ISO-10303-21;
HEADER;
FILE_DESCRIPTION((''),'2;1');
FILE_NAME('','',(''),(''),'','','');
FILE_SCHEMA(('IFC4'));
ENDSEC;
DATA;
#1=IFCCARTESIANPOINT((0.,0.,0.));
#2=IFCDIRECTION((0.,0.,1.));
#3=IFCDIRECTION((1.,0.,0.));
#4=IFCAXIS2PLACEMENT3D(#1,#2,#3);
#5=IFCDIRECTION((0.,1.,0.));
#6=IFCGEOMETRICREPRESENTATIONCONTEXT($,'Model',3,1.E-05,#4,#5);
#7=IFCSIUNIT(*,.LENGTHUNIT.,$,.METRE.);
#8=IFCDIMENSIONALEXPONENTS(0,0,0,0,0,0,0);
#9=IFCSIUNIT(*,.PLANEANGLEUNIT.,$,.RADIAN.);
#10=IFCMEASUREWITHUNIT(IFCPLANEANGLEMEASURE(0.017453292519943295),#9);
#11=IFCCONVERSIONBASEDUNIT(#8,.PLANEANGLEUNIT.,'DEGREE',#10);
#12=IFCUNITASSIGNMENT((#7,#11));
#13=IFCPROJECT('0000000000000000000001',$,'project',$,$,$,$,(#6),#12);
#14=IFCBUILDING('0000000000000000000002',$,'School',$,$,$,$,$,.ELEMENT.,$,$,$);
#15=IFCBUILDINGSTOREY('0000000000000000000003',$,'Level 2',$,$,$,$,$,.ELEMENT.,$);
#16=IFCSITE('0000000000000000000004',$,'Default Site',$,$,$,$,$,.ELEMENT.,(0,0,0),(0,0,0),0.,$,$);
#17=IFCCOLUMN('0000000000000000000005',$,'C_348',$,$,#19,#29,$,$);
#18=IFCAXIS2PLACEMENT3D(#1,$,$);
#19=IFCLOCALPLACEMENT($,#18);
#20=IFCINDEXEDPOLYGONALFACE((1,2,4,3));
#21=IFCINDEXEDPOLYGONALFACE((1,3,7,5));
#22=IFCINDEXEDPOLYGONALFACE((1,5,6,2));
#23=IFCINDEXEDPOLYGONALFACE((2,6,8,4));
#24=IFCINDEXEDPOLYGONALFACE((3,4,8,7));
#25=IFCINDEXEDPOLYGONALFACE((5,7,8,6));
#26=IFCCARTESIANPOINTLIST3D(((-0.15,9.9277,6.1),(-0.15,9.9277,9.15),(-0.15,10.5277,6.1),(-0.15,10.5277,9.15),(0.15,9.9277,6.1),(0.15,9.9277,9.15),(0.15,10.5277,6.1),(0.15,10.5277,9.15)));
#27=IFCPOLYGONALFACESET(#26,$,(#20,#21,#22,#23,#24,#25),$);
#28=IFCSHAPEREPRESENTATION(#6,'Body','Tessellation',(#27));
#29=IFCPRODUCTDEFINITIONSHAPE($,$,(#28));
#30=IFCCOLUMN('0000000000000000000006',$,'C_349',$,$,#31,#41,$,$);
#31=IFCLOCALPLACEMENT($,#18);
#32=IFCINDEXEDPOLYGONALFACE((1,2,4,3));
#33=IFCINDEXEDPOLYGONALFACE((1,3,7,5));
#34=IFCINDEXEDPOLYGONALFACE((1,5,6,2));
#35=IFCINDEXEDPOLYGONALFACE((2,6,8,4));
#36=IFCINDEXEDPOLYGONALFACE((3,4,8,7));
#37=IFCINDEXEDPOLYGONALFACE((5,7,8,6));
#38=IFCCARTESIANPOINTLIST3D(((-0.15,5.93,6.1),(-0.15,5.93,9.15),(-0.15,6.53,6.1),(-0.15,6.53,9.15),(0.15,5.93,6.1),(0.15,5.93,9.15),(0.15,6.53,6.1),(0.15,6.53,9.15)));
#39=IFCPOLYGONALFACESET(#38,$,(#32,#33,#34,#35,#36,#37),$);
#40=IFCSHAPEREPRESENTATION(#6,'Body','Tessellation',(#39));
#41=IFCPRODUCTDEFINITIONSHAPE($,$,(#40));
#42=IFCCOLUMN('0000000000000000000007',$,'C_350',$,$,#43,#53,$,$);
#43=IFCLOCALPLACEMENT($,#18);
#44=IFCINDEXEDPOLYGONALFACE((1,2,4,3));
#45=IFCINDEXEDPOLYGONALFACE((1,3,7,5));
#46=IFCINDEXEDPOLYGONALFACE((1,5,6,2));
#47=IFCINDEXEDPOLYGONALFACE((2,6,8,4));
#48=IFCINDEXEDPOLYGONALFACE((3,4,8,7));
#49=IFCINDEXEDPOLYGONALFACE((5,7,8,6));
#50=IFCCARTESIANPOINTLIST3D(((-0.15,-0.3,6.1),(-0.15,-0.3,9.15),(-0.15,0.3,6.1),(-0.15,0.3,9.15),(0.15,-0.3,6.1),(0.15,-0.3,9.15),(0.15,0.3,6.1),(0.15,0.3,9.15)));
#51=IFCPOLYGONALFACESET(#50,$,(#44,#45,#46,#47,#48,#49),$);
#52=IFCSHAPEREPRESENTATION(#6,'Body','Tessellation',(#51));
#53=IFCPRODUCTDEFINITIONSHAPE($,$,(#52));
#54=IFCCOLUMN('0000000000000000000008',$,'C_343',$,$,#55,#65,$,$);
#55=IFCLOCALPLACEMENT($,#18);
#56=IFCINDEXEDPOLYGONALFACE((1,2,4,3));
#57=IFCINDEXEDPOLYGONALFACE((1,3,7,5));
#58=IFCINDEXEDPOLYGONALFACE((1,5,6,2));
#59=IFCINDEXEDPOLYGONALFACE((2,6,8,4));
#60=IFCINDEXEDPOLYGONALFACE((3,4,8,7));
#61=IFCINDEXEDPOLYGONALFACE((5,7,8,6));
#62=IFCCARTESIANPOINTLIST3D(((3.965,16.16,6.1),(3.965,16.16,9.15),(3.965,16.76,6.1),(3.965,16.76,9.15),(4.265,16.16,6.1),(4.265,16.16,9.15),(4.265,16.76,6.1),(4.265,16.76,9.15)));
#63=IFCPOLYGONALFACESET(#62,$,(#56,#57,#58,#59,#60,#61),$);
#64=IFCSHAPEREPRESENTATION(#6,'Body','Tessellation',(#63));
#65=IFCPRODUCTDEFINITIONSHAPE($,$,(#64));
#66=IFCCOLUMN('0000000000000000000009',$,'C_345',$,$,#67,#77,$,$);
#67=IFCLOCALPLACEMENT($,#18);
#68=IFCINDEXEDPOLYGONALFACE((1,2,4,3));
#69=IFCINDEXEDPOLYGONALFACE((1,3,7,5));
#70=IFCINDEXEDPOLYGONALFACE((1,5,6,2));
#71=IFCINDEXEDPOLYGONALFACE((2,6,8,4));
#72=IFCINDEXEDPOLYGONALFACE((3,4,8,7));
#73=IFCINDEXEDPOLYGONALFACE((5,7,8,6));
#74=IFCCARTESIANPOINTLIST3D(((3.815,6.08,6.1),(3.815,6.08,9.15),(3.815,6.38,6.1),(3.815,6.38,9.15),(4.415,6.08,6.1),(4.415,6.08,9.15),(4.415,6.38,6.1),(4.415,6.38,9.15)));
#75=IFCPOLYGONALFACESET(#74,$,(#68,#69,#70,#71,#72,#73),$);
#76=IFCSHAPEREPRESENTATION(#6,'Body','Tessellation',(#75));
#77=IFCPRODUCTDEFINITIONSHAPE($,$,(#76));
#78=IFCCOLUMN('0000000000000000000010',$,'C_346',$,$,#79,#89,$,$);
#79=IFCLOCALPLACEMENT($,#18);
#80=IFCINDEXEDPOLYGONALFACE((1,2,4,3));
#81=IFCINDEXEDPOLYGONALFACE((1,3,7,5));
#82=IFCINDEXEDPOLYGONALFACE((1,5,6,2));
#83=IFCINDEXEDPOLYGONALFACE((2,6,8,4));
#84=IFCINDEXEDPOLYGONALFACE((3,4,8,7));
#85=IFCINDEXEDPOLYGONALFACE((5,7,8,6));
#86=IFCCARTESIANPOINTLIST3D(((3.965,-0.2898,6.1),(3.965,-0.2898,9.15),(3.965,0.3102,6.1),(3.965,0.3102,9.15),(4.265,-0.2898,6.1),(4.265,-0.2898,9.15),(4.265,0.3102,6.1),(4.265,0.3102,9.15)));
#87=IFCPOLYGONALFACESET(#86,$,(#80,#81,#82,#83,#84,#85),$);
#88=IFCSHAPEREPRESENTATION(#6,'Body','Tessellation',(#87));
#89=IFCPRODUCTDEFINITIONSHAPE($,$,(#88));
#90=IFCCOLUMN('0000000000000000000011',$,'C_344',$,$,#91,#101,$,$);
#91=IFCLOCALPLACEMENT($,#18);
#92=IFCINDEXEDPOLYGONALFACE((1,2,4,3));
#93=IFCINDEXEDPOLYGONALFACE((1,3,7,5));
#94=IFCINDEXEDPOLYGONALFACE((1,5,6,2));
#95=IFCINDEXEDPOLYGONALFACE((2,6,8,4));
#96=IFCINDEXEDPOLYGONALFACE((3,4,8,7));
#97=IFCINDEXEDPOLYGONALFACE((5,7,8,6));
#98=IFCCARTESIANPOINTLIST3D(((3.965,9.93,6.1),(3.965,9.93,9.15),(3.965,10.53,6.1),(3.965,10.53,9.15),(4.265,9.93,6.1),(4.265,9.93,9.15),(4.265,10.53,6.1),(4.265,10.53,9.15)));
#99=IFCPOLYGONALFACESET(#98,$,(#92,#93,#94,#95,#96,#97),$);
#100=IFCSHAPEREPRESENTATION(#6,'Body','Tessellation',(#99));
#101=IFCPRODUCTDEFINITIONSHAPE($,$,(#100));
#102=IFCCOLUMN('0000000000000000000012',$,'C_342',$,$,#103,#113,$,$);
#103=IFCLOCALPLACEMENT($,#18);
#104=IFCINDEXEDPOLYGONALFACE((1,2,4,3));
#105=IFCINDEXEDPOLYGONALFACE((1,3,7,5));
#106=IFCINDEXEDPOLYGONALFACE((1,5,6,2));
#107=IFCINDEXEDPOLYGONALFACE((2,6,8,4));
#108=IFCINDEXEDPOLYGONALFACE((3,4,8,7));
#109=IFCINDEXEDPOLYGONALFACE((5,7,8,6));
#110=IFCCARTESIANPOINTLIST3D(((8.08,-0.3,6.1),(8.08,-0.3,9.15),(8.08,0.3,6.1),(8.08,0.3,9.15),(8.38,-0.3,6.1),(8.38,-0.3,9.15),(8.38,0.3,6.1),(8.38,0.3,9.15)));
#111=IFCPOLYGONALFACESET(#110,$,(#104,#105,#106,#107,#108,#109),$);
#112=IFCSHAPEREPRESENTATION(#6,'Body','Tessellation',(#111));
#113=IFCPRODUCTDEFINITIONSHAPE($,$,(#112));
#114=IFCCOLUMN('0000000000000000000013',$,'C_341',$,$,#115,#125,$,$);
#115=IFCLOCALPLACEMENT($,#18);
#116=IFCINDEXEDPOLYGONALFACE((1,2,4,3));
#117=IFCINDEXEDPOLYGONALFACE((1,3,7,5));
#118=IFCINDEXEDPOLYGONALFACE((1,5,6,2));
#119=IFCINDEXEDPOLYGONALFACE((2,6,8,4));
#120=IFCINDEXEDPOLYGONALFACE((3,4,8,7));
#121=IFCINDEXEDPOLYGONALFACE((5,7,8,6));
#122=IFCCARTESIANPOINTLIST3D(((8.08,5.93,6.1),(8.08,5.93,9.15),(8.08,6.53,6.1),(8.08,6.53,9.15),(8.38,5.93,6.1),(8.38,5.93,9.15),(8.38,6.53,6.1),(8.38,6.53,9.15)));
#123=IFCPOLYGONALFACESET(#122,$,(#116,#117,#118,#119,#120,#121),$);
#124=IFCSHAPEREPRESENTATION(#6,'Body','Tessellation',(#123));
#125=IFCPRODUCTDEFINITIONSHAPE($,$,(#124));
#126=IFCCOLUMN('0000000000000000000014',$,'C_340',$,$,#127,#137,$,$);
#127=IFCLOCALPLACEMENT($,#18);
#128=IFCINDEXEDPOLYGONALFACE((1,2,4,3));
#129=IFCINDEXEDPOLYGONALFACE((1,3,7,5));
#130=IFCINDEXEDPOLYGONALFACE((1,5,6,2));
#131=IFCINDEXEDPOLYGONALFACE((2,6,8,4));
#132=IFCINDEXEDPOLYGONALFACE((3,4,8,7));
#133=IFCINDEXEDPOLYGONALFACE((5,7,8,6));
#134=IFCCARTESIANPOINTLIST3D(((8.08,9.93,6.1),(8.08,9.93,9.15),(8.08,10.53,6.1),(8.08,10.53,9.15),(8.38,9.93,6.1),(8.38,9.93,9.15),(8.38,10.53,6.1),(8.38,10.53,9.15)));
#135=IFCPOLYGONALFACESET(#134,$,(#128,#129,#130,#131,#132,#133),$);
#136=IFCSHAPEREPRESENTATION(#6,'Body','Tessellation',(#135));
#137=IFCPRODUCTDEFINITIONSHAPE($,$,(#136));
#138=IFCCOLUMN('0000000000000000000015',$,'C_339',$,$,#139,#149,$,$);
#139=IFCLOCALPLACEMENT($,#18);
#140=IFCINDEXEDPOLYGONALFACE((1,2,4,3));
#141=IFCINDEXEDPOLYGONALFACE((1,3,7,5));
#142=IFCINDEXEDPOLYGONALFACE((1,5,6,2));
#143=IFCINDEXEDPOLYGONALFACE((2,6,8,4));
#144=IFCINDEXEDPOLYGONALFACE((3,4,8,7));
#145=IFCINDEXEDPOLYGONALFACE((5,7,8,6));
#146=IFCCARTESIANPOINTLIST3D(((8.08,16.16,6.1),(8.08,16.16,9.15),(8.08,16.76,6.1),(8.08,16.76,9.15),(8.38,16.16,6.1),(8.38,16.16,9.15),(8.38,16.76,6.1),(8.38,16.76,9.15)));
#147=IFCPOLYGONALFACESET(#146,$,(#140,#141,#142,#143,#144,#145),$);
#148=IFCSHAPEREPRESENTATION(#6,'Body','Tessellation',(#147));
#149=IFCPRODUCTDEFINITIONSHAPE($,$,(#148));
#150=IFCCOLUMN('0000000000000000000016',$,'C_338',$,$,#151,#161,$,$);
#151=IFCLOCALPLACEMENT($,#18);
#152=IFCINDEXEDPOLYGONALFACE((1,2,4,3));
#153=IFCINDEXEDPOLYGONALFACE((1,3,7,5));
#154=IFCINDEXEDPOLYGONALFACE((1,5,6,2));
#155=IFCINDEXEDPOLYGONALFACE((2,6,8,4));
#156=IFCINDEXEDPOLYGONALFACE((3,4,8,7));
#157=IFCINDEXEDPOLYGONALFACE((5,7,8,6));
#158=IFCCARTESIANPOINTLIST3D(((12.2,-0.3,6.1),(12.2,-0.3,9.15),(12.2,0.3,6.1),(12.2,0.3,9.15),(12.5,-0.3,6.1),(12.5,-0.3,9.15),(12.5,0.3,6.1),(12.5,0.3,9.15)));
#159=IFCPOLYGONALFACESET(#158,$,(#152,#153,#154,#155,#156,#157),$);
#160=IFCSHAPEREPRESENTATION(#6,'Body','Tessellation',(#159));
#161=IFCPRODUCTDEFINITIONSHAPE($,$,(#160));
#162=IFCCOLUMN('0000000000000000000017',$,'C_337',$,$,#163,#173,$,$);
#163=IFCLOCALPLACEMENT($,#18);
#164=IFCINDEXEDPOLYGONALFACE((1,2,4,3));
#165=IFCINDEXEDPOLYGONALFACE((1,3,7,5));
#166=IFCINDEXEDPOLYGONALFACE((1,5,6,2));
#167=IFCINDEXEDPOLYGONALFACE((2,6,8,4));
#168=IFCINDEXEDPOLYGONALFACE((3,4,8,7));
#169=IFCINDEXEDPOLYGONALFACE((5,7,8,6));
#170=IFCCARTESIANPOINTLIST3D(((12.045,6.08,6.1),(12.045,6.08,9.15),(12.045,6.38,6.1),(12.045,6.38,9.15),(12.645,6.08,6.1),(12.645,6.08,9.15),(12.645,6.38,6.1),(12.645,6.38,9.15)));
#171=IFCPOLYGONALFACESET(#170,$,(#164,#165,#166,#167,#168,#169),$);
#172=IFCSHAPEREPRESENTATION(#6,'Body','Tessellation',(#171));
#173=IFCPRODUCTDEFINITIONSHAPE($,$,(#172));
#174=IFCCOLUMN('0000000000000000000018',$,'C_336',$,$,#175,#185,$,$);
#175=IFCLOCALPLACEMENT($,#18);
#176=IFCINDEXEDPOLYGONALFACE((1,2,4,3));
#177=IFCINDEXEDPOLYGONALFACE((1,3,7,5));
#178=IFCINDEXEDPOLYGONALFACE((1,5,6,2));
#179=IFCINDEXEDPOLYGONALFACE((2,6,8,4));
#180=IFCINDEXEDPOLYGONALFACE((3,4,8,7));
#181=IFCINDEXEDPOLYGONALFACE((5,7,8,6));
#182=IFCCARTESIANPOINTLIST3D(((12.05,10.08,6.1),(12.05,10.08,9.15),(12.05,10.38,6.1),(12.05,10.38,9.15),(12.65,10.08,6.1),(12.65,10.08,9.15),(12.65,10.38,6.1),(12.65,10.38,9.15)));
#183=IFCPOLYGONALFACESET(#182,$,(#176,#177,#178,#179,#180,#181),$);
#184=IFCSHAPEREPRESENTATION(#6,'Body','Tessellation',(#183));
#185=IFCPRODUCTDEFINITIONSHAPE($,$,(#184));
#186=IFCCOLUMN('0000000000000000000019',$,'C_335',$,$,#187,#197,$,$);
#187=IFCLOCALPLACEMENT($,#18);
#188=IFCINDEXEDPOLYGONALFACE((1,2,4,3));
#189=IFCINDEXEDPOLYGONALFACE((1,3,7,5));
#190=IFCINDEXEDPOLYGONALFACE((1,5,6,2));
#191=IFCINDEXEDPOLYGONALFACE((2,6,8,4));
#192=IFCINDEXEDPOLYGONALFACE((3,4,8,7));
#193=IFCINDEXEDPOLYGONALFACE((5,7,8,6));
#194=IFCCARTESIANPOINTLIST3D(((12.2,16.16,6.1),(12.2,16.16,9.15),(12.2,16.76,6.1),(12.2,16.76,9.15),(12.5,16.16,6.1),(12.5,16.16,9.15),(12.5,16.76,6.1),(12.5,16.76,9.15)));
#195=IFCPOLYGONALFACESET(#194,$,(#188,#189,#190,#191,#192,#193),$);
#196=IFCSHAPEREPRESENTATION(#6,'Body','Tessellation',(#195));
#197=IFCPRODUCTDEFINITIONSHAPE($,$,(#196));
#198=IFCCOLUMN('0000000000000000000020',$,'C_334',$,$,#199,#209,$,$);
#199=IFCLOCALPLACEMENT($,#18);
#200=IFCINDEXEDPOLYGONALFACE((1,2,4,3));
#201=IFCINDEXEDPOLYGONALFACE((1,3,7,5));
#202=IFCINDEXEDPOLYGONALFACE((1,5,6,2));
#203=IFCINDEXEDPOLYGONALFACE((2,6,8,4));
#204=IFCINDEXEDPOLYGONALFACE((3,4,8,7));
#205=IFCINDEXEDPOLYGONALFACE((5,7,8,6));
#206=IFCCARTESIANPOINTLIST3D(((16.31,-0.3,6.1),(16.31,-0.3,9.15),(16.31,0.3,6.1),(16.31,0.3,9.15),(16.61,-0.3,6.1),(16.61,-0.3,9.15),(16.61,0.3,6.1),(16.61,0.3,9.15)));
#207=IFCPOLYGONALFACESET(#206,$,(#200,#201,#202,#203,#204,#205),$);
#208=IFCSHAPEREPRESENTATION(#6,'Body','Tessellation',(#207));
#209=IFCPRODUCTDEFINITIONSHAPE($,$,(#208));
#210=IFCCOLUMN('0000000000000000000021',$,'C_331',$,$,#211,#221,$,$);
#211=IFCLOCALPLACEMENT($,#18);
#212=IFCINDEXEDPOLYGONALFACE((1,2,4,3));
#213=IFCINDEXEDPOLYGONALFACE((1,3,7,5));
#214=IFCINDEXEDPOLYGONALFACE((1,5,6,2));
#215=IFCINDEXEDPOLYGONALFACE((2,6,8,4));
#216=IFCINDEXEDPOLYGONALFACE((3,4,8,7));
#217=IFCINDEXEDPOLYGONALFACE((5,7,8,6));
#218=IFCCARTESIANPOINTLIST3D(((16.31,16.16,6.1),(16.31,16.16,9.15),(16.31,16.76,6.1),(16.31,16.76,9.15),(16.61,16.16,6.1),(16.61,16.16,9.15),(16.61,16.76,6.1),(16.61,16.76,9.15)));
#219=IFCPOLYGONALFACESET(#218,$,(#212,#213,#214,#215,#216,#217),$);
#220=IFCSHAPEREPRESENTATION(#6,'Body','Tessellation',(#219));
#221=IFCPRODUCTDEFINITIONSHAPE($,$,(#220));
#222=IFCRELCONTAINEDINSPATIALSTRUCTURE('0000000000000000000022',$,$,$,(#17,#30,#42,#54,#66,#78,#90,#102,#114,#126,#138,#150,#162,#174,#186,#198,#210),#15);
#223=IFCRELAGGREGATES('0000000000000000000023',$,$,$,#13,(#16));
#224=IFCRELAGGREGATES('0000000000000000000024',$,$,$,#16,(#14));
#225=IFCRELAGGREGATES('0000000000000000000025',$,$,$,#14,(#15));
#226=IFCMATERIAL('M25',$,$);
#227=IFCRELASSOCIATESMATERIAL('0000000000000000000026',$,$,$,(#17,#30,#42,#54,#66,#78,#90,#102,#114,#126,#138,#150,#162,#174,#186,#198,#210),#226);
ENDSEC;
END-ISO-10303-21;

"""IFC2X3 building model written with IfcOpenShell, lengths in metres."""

from ifc_helpers import new_model, entity, si_unit, converted_unit, direction, frame, frame_2d, origin_with_axes, place, context, project, spatial, rectangle, extrude, material, element, save


model = new_model("IFC2X3")

# Units and contexts
model_context = context("Model", 3, precision=1e-05, world=origin_with_axes(), true_north=direction((0.0, 1.0, 0.0)))
ifc_project = project(units=[si_unit("LENGTHUNIT", "METRE"), converted_unit("PLANEANGLEUNIT", "DEGREE", entity("IfcPlaneAngleMeasure", 0.017453292519943295), si_unit("PLANEANGLEUNIT", "RADIAN"), dimensions=[0, 0, 0, 0, 0, 0, 0])], contexts=[model_context])

# Site, building, storey
site = spatial("IfcSite", under=ifc_project, Name="Default Site", CompositionType="ELEMENT", RefLatitude=(0, 0, 0), RefLongitude=(0, 0, 0), RefElevation=0.0)
building = spatial("IfcBuilding", under=site, Name="School", CompositionType="ELEMENT")
storey = spatial("IfcBuildingStorey", under=building, Name="Level 2", CompositionType="ELEMENT")

# Columns
ifc_material = material(Name="M25")
placement = place(None, origin_with_axes())
element("IfcColumn", 1, at=placement, inside=storey, material=ifc_material, Name="C_348", context=model_context, shape_type="SweptSolid", body=[
    extrude(rectangle(XDim=0.3, YDim=0.6, at=frame_2d((0.0, 0.0), x_axis=(1.0, 0.0, 0.0))), frame((0.0, 10.2277, 6.1), z_axis=(0.0, 0.0, 1.0), x_axis=(1.0, 0.0, 0.0)), (0.0, 0.0, 1.0), 3.05),
])
element("IfcColumn", 2, at=placement, inside=storey, material=ifc_material, Name="C_349", context=model_context, shape_type="SweptSolid", body=[
    extrude(rectangle(XDim=0.3, YDim=0.6, at=frame_2d((0.0, 0.0), x_axis=(1.0, 0.0, 0.0))), frame((0.0, 6.23, 6.1), z_axis=(0.0, 0.0, 1.0), x_axis=(1.0, 0.0, 0.0)), (0.0, 0.0, 1.0), 3.05),
])
element("IfcColumn", 3, at=placement, inside=storey, material=ifc_material, Name="C_350", context=model_context, shape_type="SweptSolid", body=[
    extrude(rectangle(XDim=0.3, YDim=0.6, at=frame_2d((0.0, 0.0), x_axis=(1.0, 0.0, 0.0))), frame((0.0, 0.0, 6.1), z_axis=(0.0, 0.0, 1.0), x_axis=(1.0, 0.0, 0.0)), (0.0, 0.0, 1.0), 3.05),
])
element("IfcColumn", 4, at=placement, inside=storey, material=ifc_material, Name="C_343", context=model_context, shape_type="SweptSolid", body=[
    extrude(rectangle(XDim=0.3, YDim=0.6, at=frame_2d((0.0, 0.0), x_axis=(1.0, 0.0, 0.0))), frame((4.115, 16.46, 6.1), z_axis=(0.0, 0.0, 1.0), x_axis=(1.0, 0.0, 0.0)), (0.0, 0.0, 1.0), 3.05),
])
element("IfcColumn", 5, at=placement, inside=storey, material=ifc_material, Name="C_345", context=model_context, shape_type="SweptSolid", body=[
    extrude(rectangle(XDim=0.6, YDim=0.3, at=frame_2d((0.0, 0.0), x_axis=(1.0, 0.0, 0.0))), frame((4.115, 6.23, 6.1), z_axis=(0.0, 0.0, 1.0), x_axis=(1.0, 0.0, 0.0)), (0.0, 0.0, 1.0), 3.05),
])
element("IfcColumn", 6, at=placement, inside=storey, material=ifc_material, Name="C_346", context=model_context, shape_type="SweptSolid", body=[
    extrude(rectangle(XDim=0.3, YDim=0.6, at=frame_2d((0.0, 0.0), x_axis=(1.0, 0.0, 0.0))), frame((4.115, 0.0102, 6.1), z_axis=(0.0, 0.0, 1.0), x_axis=(1.0, 0.0, 0.0)), (0.0, 0.0, 1.0), 3.05),
])
element("IfcColumn", 7, at=placement, inside=storey, material=ifc_material, Name="C_344", context=model_context, shape_type="SweptSolid", body=[
    extrude(rectangle(XDim=0.3, YDim=0.6, at=frame_2d((0.0, 0.0), x_axis=(1.0, 0.0, 0.0))), frame((4.115, 10.23, 6.1), z_axis=(0.0, 0.0, 1.0), x_axis=(1.0, 0.0, 0.0)), (0.0, 0.0, 1.0), 3.05),
])
element("IfcColumn", 8, at=placement, inside=storey, material=ifc_material, Name="C_342", context=model_context, shape_type="SweptSolid", body=[
    extrude(rectangle(XDim=0.3, YDim=0.6, at=frame_2d((0.0, 0.0), x_axis=(1.0, 0.0, 0.0))), frame((8.23, 0.0, 6.1), z_axis=(0.0, 0.0, 1.0), x_axis=(1.0, 0.0, 0.0)), (0.0, 0.0, 1.0), 3.05),
])
element("IfcColumn", 9, at=placement, inside=storey, material=ifc_material, Name="C_341", context=model_context, shape_type="SweptSolid", body=[
    extrude(rectangle(XDim=0.3, YDim=0.6, at=frame_2d((0.0, 0.0), x_axis=(1.0, 0.0, 0.0))), frame((8.23, 6.23, 6.1), z_axis=(0.0, 0.0, 1.0), x_axis=(1.0, 0.0, 0.0)), (0.0, 0.0, 1.0), 3.05),
])
element("IfcColumn", 10, at=placement, inside=storey, material=ifc_material, Name="C_340", context=model_context, shape_type="SweptSolid", body=[
    extrude(rectangle(XDim=0.3, YDim=0.6, at=frame_2d((0.0, 0.0), x_axis=(1.0, 0.0, 0.0))), frame((8.23, 10.23, 6.1), z_axis=(0.0, 0.0, 1.0), x_axis=(1.0, 0.0, 0.0)), (0.0, 0.0, 1.0), 3.05),
])
element("IfcColumn", 11, at=placement, inside=storey, material=ifc_material, Name="C_339", context=model_context, shape_type="SweptSolid", body=[
    extrude(rectangle(XDim=0.3, YDim=0.6, at=frame_2d((0.0, 0.0), x_axis=(1.0, 0.0, 0.0))), frame((8.23, 16.46, 6.1), z_axis=(0.0, 0.0, 1.0), x_axis=(1.0, 0.0, 0.0)), (0.0, 0.0, 1.0), 3.05),
])
element("IfcColumn", 12, at=placement, inside=storey, material=ifc_material, Name="C_338", context=model_context, shape_type="SweptSolid", body=[
    extrude(rectangle(XDim=0.3, YDim=0.6, at=frame_2d((0.0, 0.0), x_axis=(1.0, 0.0, 0.0))), frame((12.35, 0.0, 6.1), z_axis=(0.0, 0.0, 1.0), x_axis=(1.0, 0.0, 0.0)), (0.0, 0.0, 1.0), 3.05),
])
element("IfcColumn", 13, at=placement, inside=storey, material=ifc_material, Name="C_337", context=model_context, shape_type="SweptSolid", body=[
    extrude(rectangle(XDim=0.6, YDim=0.3, at=frame_2d((0.0, 0.0), x_axis=(1.0, 0.0, 0.0))), frame((12.345, 6.23, 6.1), z_axis=(0.0, 0.0, 1.0), x_axis=(1.0, 0.0, 0.0)), (0.0, 0.0, 1.0), 3.05),
])
element("IfcColumn", 14, at=placement, inside=storey, material=ifc_material, Name="C_336", context=model_context, shape_type="SweptSolid", body=[
    extrude(rectangle(XDim=0.6, YDim=0.3, at=frame_2d((0.0, 0.0), x_axis=(1.0, 0.0, 0.0))), frame((12.35, 10.23, 6.1), z_axis=(0.0, 0.0, 1.0), x_axis=(1.0, 0.0, 0.0)), (0.0, 0.0, 1.0), 3.05),
])
element("IfcColumn", 15, at=placement, inside=storey, material=ifc_material, Name="C_335", context=model_context, shape_type="SweptSolid", body=[
    extrude(rectangle(XDim=0.3, YDim=0.6, at=frame_2d((0.0, 0.0), x_axis=(1.0, 0.0, 0.0))), frame((12.35, 16.46, 6.1), z_axis=(0.0, 0.0, 1.0), x_axis=(1.0, 0.0, 0.0)), (0.0, 0.0, 1.0), 3.05),
])
element("IfcColumn", 16, at=placement, inside=storey, material=ifc_material, Name="C_334", context=model_context, shape_type="SweptSolid", body=[
    extrude(rectangle(XDim=0.3, YDim=0.6, at=frame_2d((0.0, 0.0), x_axis=(1.0, 0.0, 0.0))), frame((16.46, 0.0, 6.1), z_axis=(0.0, 0.0, 1.0), x_axis=(1.0, 0.0, 0.0)), (0.0, 0.0, 1.0), 3.05),
])
element("IfcColumn", 17, at=placement, inside=storey, material=ifc_material, Name="C_331", context=model_context, shape_type="SweptSolid", body=[
    extrude(rectangle(XDim=0.3, YDim=0.6, at=frame_2d((0.0, 0.0), x_axis=(1.0, 0.0, 0.0))), frame((16.46, 16.46, 6.1), z_axis=(0.0, 0.0, 1.0), x_axis=(1.0, 0.0, 0.0)), (0.0, 0.0, 1.0), 3.05),
])

save(model, "model.ifc")
